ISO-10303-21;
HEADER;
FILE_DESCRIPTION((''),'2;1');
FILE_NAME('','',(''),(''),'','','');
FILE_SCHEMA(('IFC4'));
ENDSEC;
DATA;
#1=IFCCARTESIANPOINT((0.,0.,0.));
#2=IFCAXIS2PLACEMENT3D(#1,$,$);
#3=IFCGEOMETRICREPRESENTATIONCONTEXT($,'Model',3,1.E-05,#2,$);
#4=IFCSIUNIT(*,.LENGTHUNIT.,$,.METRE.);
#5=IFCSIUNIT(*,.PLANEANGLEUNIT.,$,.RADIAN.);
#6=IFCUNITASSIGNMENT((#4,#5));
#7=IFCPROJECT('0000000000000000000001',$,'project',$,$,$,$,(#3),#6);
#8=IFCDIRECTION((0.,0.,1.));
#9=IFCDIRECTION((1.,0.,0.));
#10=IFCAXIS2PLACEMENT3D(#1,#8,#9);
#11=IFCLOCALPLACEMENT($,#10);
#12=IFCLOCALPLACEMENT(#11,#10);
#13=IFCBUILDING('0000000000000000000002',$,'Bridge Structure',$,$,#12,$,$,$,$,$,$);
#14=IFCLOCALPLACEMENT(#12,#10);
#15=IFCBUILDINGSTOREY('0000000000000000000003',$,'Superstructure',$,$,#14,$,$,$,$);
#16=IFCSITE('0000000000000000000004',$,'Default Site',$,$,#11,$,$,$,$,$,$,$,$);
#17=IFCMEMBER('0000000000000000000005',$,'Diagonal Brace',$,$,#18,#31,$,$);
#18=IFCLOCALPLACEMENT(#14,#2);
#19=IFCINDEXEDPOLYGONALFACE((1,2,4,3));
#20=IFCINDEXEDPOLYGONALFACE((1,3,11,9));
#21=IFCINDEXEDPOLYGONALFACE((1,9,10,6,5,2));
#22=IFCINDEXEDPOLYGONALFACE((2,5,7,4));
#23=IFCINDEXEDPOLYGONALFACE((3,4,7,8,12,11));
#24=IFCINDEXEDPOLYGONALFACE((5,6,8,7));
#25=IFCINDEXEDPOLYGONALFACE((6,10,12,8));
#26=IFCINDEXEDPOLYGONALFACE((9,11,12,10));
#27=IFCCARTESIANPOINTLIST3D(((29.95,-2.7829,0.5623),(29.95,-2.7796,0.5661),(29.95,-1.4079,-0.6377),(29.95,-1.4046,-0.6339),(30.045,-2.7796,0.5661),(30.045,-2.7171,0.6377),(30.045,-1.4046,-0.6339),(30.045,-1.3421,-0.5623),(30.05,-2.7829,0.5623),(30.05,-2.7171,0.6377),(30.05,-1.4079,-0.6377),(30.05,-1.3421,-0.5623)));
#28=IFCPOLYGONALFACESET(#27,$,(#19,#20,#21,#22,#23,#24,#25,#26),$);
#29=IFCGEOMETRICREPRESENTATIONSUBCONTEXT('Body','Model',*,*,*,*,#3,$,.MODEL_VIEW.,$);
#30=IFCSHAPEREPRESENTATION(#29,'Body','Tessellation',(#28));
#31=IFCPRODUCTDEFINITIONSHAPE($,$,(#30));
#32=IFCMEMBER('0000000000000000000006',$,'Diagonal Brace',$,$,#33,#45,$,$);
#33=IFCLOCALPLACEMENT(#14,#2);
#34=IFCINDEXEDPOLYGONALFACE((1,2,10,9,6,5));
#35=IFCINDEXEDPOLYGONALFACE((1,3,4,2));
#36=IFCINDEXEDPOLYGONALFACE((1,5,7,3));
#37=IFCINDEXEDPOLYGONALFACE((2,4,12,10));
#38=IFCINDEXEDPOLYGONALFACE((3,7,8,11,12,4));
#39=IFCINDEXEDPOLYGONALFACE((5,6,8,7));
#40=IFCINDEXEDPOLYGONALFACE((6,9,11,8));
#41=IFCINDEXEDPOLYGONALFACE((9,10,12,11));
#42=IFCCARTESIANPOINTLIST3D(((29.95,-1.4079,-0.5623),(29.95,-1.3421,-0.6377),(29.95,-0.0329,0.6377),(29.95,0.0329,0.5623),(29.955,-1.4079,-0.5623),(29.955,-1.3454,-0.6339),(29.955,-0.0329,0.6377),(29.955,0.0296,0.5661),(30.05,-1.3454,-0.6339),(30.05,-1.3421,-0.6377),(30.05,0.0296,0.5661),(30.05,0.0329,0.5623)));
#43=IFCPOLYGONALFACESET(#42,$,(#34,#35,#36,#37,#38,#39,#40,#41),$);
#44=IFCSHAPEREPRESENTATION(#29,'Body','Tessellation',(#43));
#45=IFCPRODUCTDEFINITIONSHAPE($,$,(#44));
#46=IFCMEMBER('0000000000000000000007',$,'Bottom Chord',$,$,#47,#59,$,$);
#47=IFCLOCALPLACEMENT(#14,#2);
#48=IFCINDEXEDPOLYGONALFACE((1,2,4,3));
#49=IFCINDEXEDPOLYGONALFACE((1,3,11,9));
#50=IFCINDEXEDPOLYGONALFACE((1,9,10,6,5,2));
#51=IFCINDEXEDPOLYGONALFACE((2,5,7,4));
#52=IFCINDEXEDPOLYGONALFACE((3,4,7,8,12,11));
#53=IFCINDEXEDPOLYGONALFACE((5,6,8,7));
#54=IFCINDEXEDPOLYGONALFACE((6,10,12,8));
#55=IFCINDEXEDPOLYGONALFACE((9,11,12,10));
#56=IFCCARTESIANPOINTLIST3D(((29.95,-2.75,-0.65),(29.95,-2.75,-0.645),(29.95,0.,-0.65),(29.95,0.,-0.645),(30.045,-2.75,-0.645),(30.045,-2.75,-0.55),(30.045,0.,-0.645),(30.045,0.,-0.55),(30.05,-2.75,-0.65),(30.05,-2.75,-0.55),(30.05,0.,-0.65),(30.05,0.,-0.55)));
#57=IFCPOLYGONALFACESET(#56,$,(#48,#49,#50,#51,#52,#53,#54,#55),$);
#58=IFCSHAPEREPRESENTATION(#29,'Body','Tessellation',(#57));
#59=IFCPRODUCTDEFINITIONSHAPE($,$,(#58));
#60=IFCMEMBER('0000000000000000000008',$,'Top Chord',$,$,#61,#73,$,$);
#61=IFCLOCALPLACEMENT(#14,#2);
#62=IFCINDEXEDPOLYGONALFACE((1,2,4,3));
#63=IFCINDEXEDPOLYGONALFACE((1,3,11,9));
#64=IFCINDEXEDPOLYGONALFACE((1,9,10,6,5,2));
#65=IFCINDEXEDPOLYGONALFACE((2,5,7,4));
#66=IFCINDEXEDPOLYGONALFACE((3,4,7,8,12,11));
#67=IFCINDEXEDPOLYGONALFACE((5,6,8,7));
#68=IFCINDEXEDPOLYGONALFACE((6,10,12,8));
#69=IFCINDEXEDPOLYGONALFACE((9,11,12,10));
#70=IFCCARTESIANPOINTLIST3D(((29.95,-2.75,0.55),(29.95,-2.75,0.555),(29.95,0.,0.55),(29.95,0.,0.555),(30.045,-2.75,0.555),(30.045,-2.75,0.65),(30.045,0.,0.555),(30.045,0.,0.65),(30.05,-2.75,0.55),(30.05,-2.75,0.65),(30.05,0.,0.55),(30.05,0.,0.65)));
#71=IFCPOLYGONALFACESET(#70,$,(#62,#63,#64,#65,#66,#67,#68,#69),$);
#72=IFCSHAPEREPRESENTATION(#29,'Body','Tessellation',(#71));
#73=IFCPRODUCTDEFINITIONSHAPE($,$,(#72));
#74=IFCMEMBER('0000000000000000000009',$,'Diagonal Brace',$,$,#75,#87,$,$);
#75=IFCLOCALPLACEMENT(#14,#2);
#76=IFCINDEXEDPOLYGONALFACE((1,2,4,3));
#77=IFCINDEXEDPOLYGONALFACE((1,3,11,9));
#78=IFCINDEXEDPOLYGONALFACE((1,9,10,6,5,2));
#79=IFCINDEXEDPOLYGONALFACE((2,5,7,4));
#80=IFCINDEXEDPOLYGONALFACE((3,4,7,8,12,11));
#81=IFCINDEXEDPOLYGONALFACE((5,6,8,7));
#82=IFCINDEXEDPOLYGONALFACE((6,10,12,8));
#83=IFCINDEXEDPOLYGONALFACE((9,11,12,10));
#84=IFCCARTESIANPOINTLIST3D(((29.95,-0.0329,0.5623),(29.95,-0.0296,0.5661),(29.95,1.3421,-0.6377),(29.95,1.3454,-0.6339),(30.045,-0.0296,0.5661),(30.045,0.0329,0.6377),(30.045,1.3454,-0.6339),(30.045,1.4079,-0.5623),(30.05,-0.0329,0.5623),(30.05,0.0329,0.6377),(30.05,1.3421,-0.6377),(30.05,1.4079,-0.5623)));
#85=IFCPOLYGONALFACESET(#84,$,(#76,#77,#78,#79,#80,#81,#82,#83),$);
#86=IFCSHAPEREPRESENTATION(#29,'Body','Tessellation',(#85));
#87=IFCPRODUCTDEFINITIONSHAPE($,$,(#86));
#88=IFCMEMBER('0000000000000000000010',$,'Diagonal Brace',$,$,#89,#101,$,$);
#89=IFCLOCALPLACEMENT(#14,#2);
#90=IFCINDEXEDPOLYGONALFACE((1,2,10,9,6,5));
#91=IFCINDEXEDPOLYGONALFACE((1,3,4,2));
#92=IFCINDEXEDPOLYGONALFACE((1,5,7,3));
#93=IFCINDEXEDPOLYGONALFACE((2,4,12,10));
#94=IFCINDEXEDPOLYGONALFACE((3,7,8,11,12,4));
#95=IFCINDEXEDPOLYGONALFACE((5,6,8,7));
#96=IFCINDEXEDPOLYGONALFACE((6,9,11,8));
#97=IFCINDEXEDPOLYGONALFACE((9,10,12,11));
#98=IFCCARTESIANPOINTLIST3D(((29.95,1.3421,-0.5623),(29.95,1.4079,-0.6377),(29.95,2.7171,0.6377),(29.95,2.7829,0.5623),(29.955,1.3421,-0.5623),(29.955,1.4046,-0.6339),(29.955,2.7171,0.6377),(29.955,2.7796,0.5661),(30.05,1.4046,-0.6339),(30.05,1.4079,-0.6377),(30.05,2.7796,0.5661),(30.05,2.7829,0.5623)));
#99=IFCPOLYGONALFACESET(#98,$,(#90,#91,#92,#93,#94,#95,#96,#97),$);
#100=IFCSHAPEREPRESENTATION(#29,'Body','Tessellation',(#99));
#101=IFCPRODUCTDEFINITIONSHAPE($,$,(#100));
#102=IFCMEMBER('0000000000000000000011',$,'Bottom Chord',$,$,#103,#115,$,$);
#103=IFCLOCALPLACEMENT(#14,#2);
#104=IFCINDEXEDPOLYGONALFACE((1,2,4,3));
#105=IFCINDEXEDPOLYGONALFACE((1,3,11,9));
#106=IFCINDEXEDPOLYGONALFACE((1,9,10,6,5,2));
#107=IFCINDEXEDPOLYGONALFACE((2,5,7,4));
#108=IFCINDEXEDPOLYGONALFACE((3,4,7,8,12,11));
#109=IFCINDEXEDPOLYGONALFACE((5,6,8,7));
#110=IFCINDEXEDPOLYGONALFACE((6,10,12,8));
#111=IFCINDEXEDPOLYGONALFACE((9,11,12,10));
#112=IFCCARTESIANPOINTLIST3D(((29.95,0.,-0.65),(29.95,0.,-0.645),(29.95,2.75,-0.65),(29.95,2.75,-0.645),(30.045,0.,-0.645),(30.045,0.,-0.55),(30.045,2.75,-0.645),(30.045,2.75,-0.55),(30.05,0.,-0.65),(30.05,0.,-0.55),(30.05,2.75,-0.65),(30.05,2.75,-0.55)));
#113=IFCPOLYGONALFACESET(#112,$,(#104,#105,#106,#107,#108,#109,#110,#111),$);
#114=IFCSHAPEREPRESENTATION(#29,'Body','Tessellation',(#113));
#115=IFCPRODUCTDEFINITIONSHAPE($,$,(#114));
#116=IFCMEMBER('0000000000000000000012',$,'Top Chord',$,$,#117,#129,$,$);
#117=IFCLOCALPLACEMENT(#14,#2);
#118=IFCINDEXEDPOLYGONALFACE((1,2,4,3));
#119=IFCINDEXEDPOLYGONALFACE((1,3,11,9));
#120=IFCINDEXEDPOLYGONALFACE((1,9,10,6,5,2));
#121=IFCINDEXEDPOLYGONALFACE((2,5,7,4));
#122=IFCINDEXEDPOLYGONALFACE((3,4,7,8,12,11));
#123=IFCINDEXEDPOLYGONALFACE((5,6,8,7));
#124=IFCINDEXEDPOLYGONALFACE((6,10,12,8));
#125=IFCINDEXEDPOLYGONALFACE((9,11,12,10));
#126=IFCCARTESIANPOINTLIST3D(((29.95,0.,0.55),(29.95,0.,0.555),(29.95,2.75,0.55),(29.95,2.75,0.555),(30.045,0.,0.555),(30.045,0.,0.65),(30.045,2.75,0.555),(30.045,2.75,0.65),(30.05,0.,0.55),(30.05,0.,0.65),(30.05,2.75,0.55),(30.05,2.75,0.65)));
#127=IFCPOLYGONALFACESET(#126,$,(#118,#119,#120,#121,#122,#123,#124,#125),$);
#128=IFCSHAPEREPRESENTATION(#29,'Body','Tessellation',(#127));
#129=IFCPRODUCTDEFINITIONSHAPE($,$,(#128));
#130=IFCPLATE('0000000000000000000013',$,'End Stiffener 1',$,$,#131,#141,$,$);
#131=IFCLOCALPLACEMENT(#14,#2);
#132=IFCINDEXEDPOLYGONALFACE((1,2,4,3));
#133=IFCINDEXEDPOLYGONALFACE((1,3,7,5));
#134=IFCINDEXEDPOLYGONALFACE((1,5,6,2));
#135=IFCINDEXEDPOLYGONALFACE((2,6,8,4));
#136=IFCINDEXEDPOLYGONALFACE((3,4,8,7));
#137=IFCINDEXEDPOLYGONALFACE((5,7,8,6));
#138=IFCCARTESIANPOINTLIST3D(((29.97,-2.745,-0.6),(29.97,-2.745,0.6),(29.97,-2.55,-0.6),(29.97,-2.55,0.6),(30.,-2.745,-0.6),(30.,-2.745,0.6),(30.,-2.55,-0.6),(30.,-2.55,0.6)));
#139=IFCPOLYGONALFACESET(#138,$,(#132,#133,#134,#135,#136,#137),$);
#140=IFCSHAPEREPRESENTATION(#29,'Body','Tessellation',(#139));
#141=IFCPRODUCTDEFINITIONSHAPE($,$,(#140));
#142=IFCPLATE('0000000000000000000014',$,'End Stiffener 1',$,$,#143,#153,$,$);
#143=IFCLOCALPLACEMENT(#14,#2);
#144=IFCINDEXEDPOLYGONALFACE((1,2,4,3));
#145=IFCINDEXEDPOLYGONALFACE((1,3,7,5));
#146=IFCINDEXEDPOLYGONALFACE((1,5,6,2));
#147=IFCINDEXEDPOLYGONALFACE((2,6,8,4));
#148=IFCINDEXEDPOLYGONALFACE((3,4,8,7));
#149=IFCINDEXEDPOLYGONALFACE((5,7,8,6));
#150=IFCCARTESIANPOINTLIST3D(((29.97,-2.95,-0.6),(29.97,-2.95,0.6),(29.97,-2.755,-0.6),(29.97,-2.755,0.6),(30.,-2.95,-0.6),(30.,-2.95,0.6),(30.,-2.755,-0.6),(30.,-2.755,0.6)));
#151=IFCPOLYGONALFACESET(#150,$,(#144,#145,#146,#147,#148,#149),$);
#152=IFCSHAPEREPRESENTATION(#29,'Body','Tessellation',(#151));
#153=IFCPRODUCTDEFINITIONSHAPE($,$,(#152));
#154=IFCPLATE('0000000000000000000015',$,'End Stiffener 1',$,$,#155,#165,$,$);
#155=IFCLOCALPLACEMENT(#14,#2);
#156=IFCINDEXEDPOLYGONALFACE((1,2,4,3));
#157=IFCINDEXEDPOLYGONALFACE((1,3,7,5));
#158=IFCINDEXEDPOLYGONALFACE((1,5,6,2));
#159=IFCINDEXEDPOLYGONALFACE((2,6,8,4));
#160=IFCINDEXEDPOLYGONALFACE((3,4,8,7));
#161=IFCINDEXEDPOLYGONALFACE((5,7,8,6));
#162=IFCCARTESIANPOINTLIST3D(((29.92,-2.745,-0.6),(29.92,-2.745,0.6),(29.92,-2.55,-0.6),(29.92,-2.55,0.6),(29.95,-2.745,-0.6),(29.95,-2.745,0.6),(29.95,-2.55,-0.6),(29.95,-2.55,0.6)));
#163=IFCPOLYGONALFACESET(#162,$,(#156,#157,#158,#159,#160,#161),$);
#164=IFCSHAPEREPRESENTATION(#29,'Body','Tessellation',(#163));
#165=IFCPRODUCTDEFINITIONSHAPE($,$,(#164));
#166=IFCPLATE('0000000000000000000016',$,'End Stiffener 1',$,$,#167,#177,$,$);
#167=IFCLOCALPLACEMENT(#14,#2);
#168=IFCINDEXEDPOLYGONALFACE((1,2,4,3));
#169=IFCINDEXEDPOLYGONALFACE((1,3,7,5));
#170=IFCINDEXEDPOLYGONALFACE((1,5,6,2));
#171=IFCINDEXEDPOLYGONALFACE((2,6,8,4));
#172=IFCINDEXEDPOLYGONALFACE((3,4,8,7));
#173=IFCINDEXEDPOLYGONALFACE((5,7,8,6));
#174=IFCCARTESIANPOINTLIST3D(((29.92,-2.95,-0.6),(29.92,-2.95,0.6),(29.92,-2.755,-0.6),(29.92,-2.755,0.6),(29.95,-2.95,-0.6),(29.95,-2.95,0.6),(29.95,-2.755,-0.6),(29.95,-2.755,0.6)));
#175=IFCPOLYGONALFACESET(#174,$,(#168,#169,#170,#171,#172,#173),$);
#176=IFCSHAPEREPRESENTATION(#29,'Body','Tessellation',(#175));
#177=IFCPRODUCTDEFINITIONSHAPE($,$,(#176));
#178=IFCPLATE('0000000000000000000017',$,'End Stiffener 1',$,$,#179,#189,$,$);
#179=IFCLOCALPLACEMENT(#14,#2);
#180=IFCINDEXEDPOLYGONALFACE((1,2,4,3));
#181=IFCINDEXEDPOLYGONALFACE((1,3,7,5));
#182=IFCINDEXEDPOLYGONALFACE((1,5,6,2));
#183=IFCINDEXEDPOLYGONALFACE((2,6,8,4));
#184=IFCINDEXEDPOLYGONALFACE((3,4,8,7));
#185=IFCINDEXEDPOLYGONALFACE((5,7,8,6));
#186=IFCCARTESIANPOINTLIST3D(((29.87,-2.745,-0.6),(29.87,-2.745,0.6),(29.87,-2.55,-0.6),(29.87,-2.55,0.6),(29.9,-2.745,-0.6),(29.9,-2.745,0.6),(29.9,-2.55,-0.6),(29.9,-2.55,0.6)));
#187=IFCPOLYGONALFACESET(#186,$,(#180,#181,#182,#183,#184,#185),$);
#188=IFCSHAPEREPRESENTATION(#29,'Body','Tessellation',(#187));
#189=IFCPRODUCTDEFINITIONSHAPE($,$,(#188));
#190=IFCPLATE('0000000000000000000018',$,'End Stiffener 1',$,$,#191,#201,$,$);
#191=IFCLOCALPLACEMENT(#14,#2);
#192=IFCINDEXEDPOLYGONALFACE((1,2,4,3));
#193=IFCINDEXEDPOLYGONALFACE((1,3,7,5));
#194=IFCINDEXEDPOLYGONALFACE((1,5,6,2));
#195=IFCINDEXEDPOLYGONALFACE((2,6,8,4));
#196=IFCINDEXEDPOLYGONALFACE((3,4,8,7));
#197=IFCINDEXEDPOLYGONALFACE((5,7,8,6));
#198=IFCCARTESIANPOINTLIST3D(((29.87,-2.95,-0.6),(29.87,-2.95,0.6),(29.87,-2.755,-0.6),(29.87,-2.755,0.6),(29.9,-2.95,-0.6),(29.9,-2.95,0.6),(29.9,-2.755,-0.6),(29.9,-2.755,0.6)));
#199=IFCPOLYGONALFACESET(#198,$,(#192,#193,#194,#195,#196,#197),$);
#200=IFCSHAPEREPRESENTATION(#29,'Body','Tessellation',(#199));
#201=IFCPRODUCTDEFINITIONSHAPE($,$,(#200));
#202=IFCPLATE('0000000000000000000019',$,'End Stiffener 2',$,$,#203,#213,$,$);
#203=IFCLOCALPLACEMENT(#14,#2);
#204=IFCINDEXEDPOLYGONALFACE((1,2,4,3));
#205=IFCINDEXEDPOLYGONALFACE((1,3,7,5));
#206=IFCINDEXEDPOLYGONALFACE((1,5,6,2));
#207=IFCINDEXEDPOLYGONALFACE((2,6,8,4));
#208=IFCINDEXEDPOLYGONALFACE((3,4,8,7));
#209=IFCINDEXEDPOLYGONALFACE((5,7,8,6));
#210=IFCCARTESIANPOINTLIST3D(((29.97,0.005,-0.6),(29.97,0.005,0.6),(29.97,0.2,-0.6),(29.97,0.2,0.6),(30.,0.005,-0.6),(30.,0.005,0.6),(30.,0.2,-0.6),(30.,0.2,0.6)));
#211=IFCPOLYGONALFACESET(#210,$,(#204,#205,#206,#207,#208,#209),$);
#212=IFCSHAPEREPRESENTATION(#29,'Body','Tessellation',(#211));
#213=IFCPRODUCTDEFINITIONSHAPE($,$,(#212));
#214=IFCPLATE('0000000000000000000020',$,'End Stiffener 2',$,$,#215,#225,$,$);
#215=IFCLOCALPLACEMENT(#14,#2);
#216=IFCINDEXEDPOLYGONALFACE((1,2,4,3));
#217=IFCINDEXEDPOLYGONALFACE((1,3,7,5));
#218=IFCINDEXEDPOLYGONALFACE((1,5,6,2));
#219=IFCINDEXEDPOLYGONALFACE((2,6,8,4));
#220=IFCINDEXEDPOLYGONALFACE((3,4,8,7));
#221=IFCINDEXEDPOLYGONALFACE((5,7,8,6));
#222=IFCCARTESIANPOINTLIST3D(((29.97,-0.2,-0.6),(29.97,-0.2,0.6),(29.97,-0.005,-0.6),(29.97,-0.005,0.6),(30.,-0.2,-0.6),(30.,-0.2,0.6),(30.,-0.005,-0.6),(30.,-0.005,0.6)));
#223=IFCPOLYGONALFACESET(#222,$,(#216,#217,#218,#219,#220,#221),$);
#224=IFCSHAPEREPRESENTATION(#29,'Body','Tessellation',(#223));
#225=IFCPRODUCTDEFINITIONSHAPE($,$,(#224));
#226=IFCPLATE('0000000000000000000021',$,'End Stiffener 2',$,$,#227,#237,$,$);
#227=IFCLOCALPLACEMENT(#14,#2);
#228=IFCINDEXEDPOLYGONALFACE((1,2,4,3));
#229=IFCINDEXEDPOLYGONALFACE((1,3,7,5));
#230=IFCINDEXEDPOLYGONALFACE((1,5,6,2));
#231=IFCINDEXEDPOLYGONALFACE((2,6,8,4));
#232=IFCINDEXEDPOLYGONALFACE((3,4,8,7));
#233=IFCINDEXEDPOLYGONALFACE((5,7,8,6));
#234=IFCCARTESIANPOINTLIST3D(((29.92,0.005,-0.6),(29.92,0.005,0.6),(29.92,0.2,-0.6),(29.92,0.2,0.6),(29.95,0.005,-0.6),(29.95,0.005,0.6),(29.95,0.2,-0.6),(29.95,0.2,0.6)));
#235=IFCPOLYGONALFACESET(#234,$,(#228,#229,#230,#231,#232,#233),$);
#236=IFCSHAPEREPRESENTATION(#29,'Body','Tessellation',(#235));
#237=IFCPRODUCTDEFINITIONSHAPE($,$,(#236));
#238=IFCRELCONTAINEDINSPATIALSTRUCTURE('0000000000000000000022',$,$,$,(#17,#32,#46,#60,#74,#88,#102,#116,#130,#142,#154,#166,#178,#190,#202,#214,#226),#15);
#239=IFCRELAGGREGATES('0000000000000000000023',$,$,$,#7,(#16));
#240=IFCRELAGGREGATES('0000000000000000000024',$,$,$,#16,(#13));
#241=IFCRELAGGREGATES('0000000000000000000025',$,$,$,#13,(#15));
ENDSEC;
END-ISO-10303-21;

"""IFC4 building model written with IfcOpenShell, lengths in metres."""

from ifc_helpers import new_model, si_unit, frame, origin, origin_with_axes, origin_2d_with_axis, place, context, subcontext, project, spatial, rectangle, l_section, extrude, element, save


model = new_model("IFC4")

# Units and contexts
model_context = context("Model", 3, precision=1e-05, world=origin())
body_context = subcontext(model_context, "Body", "Model", "MODEL_VIEW")
ifc_project = project(units=[si_unit("LENGTHUNIT", "METRE"), si_unit("PLANEANGLEUNIT", "RADIAN")], contexts=[model_context])

# Site, building, storey
site_placement = place(None, origin_with_axes())
site = spatial("IfcSite", under=ifc_project, at=site_placement, Name="Default Site")
building_placement = place(site_placement, origin_with_axes())
building = spatial("IfcBuilding", under=site, at=building_placement, Name="Bridge Structure")
storey_placement = place(building_placement, origin_with_axes())
storey = spatial("IfcBuildingStorey", under=building, at=storey_placement, Name="Superstructure")

# Members
for number, where, z_axis, x_axis, name in (
    (1, (30.0, -2.75, 0.6), (0.0, 0.753425, -0.657534), (-1.0, 0.0, 0.0), "Diagonal Brace"),
    (2, (30.0, 0.0, 0.6), (0.0, -0.753425, -0.657534), (1.0, 0.0, 0.0), "Diagonal Brace"),
):
    element("IfcMember", number, at=place(storey_placement, frame(where, z_axis=z_axis, x_axis=x_axis)), inside=storey, Name=name, context=body_context, shape_type="SweptSolid", body=[
        extrude(l_section(Depth=0.1, Width=0.1, Thickness=0.005, at=origin_2d_with_axis()), origin_with_axes(), (0.0, 0.0, 1.0), 1.825),
    ])
for number, where, z_axis, x_axis, name in (
    (3, (30.0, -2.75, -0.6), (0.0, 1.0, 0.0), (-1.0, 0.0, 0.0), "Bottom Chord"),
    (4, (30.0, -2.75, 0.6), (0.0, 1.0, 0.0), (-1.0, 0.0, 0.0), "Top Chord"),
):
    element("IfcMember", number, at=place(storey_placement, frame(where, z_axis=z_axis, x_axis=x_axis)), inside=storey, Name=name, context=body_context, shape_type="SweptSolid", body=[
        extrude(l_section(Depth=0.1, Width=0.1, Thickness=0.005, at=origin_2d_with_axis()), origin_with_axes(), (0.0, 0.0, 1.0), 2.75),
    ])
for number, where, z_axis, x_axis, name in (
    (5, (30.0, 0.0, 0.6), (0.0, 0.753425, -0.657534), (-1.0, 0.0, 0.0), "Diagonal Brace"),
    (6, (30.0, 2.75, 0.6), (0.0, -0.753425, -0.657534), (1.0, 0.0, 0.0), "Diagonal Brace"),
):
    element("IfcMember", number, at=place(storey_placement, frame(where, z_axis=z_axis, x_axis=x_axis)), inside=storey, Name=name, context=body_context, shape_type="SweptSolid", body=[
        extrude(l_section(Depth=0.1, Width=0.1, Thickness=0.005, at=origin_2d_with_axis()), origin_with_axes(), (0.0, 0.0, 1.0), 1.825),
    ])
for number, where, z_axis, x_axis, name in (
    (7, (30.0, 0.0, -0.6), (0.0, 1.0, 0.0), (-1.0, 0.0, 0.0), "Bottom Chord"),
    (8, (30.0, 0.0, 0.6), (0.0, 1.0, 0.0), (-1.0, 0.0, 0.0), "Top Chord"),
):
    element("IfcMember", number, at=place(storey_placement, frame(where, z_axis=z_axis, x_axis=x_axis)), inside=storey, Name=name, context=body_context, shape_type="SweptSolid", body=[
        extrude(l_section(Depth=0.1, Width=0.1, Thickness=0.005, at=origin_2d_with_axis()), origin_with_axes(), (0.0, 0.0, 1.0), 2.75),
    ])

# Plates
for number, where, z_axis, x_axis, name in (
    (9, (29.985, -2.6475, -0.6), (0.0, 0.0, 1.0), (1.0, 0.0, 0.0), "End Stiffener 1"),
    (10, (29.985, -2.8525, -0.6), (0.0, 0.0, 1.0), (1.0, 0.0, 0.0), "End Stiffener 1"),
    (11, (29.935, -2.6475, -0.6), (0.0, 0.0, 1.0), (1.0, 0.0, 0.0), "End Stiffener 1"),
    (12, (29.935, -2.8525, -0.6), (0.0, 0.0, 1.0), (1.0, 0.0, 0.0), "End Stiffener 1"),
    (13, (29.885, -2.6475, -0.6), (0.0, 0.0, 1.0), (1.0, 0.0, 0.0), "End Stiffener 1"),
    (14, (29.885, -2.8525, -0.6), (0.0, 0.0, 1.0), (1.0, 0.0, 0.0), "End Stiffener 1"),
    (15, (29.985, 0.1025, -0.6), (0.0, 0.0, 1.0), (1.0, 0.0, 0.0), "End Stiffener 2"),
    (16, (29.985, -0.1025, -0.6), (0.0, 0.0, 1.0), (1.0, 0.0, 0.0), "End Stiffener 2"),
    (17, (29.935, 0.1025, -0.6), (0.0, 0.0, 1.0), (1.0, 0.0, 0.0), "End Stiffener 2"),
):
    element("IfcPlate", number, at=place(storey_placement, frame(where, z_axis=z_axis, x_axis=x_axis)), inside=storey, Name=name, context=body_context, shape_type="SweptSolid", body=[
        extrude(rectangle(XDim=0.03, YDim=0.195, at=origin_2d_with_axis()), origin_with_axes(), (0.0, 0.0, 1.0), 1.2),
    ])

save(model, "model.ifc")
